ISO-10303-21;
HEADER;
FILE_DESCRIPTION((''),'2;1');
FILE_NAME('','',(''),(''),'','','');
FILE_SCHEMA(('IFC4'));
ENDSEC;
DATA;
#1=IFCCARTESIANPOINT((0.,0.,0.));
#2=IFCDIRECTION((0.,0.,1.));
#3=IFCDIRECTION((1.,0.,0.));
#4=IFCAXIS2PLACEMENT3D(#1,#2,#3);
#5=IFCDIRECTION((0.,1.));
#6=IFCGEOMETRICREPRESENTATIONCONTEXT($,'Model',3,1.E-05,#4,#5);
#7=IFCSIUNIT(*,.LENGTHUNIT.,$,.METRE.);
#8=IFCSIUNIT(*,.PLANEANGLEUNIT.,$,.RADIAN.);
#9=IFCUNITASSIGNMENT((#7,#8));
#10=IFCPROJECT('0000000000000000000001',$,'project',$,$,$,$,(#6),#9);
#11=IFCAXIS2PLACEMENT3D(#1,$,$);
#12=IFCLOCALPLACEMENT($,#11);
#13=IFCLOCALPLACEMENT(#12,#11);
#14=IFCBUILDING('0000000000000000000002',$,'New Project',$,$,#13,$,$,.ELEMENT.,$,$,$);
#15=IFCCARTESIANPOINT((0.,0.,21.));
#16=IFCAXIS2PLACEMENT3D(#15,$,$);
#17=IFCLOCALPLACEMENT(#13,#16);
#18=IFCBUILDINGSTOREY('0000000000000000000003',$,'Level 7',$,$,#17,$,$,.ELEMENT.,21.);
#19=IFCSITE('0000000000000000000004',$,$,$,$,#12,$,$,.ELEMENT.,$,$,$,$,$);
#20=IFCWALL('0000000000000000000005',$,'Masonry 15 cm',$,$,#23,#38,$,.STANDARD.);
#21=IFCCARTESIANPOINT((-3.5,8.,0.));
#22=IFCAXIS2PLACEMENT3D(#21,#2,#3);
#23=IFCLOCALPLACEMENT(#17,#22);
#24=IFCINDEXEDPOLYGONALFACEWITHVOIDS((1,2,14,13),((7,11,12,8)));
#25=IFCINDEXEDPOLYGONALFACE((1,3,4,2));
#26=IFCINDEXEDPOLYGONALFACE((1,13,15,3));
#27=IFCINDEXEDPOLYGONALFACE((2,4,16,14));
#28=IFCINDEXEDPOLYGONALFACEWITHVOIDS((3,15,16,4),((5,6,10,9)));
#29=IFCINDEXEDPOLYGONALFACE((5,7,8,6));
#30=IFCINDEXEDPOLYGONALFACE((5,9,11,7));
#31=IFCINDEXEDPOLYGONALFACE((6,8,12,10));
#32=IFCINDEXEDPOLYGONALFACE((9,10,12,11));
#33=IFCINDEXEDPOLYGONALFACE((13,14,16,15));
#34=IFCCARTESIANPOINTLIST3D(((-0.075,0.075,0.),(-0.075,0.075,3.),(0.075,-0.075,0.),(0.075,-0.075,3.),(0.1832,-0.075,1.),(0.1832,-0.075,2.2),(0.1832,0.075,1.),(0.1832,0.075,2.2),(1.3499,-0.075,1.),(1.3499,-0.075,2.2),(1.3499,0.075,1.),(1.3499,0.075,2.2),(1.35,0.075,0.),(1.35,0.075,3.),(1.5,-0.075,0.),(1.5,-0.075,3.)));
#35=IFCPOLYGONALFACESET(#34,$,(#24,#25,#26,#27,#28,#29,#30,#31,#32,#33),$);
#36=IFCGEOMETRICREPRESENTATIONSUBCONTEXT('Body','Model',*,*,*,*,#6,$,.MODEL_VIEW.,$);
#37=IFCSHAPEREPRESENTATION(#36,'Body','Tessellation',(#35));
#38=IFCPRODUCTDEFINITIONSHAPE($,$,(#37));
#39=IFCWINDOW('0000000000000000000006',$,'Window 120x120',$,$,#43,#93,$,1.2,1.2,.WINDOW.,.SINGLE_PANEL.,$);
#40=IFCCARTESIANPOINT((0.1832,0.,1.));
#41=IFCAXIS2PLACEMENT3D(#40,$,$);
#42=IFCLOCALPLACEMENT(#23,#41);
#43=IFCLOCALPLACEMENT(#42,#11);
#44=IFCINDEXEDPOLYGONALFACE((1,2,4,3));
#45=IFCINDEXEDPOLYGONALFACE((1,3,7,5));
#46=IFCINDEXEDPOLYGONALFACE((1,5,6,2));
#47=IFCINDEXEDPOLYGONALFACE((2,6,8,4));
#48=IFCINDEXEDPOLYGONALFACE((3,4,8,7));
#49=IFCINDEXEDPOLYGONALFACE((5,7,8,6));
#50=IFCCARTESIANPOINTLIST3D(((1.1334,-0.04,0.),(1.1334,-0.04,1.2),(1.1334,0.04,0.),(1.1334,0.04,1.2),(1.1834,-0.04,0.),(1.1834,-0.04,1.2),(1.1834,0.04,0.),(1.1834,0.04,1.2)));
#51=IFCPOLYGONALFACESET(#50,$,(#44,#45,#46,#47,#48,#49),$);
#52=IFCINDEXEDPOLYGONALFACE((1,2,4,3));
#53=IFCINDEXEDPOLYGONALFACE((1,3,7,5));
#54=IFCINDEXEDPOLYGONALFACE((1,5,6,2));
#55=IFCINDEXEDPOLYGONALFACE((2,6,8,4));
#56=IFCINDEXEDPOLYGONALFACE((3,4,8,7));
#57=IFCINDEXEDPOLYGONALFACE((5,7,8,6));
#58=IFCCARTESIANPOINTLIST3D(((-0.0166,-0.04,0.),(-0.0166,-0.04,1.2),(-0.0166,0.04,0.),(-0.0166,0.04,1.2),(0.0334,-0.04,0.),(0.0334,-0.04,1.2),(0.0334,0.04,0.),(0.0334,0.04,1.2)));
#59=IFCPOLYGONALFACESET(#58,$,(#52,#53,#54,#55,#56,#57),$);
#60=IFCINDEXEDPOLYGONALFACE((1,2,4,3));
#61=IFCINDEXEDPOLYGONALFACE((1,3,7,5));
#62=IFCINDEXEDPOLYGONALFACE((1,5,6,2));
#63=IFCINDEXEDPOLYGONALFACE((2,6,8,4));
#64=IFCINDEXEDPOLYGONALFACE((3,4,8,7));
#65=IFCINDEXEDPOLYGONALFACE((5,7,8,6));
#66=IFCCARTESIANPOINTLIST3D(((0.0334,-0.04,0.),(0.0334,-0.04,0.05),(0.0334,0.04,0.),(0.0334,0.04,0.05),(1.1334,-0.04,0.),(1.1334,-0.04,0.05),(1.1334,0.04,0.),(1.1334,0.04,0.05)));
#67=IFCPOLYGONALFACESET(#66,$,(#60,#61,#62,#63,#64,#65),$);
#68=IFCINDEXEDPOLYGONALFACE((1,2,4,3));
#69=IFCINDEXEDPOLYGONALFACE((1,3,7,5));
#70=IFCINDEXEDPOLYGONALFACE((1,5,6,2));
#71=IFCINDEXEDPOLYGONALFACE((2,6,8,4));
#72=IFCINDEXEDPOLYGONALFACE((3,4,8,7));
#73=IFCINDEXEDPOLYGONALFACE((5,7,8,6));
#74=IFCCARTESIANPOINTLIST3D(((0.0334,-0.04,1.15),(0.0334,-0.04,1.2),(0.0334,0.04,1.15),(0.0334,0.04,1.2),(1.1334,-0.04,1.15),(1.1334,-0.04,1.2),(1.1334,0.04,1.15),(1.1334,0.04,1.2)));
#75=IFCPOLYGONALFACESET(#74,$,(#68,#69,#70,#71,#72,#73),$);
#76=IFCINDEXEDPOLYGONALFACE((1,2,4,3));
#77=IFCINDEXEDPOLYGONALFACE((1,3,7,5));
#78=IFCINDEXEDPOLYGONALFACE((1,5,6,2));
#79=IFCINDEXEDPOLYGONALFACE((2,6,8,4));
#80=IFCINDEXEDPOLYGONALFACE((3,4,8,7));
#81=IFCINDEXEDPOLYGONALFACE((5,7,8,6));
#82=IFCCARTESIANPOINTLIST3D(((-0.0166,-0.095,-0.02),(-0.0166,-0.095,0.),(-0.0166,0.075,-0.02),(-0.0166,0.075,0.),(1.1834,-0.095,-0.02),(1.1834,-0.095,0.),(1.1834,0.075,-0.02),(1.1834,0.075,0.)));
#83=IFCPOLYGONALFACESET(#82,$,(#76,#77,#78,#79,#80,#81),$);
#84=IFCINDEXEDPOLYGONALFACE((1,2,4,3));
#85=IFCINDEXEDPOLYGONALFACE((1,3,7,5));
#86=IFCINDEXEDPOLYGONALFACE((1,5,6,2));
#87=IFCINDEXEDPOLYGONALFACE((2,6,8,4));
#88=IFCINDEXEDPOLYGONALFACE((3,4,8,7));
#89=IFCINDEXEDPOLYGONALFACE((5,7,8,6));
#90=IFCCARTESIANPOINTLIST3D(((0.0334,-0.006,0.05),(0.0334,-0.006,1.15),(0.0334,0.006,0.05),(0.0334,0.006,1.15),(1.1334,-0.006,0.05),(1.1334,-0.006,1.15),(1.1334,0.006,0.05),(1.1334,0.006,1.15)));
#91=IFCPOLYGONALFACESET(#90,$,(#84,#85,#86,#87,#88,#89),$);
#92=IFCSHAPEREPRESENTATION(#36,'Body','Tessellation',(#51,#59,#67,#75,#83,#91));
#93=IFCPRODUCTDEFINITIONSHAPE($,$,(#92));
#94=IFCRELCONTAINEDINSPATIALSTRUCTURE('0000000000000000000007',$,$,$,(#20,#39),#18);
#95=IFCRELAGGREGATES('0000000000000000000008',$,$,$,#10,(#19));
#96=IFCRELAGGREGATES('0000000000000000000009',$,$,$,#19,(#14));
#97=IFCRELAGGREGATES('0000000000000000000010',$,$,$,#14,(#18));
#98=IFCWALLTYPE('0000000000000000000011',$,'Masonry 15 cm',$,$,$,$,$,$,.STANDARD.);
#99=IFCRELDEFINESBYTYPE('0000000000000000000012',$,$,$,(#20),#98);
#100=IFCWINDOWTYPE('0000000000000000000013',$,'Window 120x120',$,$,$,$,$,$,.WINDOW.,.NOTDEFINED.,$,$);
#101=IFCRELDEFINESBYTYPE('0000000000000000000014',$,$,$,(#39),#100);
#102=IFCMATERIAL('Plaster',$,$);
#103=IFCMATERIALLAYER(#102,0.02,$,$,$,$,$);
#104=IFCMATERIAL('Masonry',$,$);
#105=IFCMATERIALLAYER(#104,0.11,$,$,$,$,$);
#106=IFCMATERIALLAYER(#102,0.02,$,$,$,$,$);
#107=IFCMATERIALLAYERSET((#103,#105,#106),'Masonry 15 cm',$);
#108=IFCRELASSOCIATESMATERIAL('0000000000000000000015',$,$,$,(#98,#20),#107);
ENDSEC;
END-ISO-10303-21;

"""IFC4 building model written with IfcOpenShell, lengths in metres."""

from ifc_helpers import new_model, si_unit, direction, frame, frame_2d, origin, origin_with_axes, place, context, subcontext, project, spatial, polyline, rectangle, outline, extrude, material, layer, layer_set, layer_usage, type_object, element, fill, save


model = new_model("IFC4")

# Units and contexts
model_context = context("Model", 3, precision=1e-05, world=origin_with_axes(), true_north=direction((0.0, 1.0)))
body_context = subcontext(model_context, "Body", "Model", "MODEL_VIEW")
ifc_project = project(units=[si_unit("LENGTHUNIT", "METRE"), si_unit("PLANEANGLEUNIT", "RADIAN")], contexts=[model_context])

# Site, building, storey
site_placement = place(None, origin())
site = spatial("IfcSite", under=ifc_project, at=site_placement, CompositionType="ELEMENT")
building_placement = place(site_placement, origin())
building = spatial("IfcBuilding", under=site, at=building_placement, Name="New Project", CompositionType="ELEMENT")
storey_placement = place(building_placement, frame((0.0, 0.0, 21.0)))
storey = spatial("IfcBuildingStorey", under=building, at=storey_placement, Name="Level 7", CompositionType="ELEMENT", Elevation=21.0)

# Shared definitions
ifc_material_1 = material(Name="Plaster")
ifc_layer_1 = layer(ifc_material_1, 0.02)
ifc_material_2 = material(Name="Masonry")
ifc_layer_2 = layer(ifc_material_2, 0.11)
ifc_layer_3 = layer(ifc_material_1, 0.02)
ifc_layer_set_1 = layer_set([ifc_layer_1, ifc_layer_2, ifc_layer_3], Name="Masonry 15 cm")
ifc_layer_usage_1 = layer_usage(ifc_layer_set_1, "AXIS2", "NEGATIVE", 0.075)
wall_type = type_object("IfcWallType", Name="Masonry 15 cm", PredefinedType="STANDARD", material=ifc_layer_set_1)
window_type = type_object("IfcWindowType", Name="Window 120x120", PartitioningType="NOTDEFINED", PredefinedType="WINDOW")

# Wall, opening, window
wall_1_placement = place(storey_placement, frame((-3.5, 8.0, 0.0), z_axis=(0.0, 0.0, 1.0), x_axis=(1.0, 0.0, 0.0)))
wall_1 = element("IfcWall", 1, at=wall_1_placement, inside=storey, type_object=wall_type, material=ifc_layer_usage_1, Name="Masonry 15 cm", PredefinedType="STANDARD", context=body_context, shape_type="SweptSolid", body=[
    extrude(outline(polyline([(0.075, -0.075), (1.5, -0.075), (1.35, 0.075), (-0.075, 0.075), (0.075, -0.075)])), origin(), (0.0, 0.0, 1.0), 3.0),
])
opening_1_placement = place(wall_1_placement, frame((0.1832, 0.0, 1.0)))
opening_1 = element("IfcOpeningElement", 2, at=opening_1_placement, cuts=wall_1, PredefinedType="OPENING", context=body_context, shape_type="SweptSolid", body=[
    extrude(rectangle(XDim=1.1667, YDim=0.25, at=frame_2d((0.5834, 0.0))), origin(), (0.0, 0.0, 1.0), 1.2),
])
window_1_placement = place(opening_1_placement, origin())
window_1 = element("IfcWindow", 3, at=window_1_placement, inside=storey, type_object=window_type, Name="Window 120x120", OverallHeight=1.2, OverallWidth=1.2, PartitioningType="SINGLE_PANEL", PredefinedType="WINDOW", context=body_context, shape_type="SweptSolid", body=[
    extrude(outline(polyline([(1.1834, 0.04), (1.1334, 0.04), (1.1334, -0.04), (1.1834, -0.04), (1.1834, 0.04)])), origin(), (0.0, 0.0, 1.0), 1.2),
    extrude(outline(polyline([(0.0334, 0.04), (-0.0166, 0.04), (-0.0166, -0.04), (0.0334, -0.04), (0.0334, 0.04)])), origin(), (0.0, 0.0, 1.0), 1.2),
    extrude(outline(polyline([(1.1334, 0.04), (0.0334, 0.04), (0.0334, -0.04), (1.1334, -0.04), (1.1334, 0.04)])), origin(), (0.0, 0.0, 1.0), 0.05),
    extrude(outline(polyline([(1.1334, 0.04), (0.0334, 0.04), (0.0334, -0.04), (1.1334, -0.04), (1.1334, 0.04)])), frame((0.0, 0.0, 1.15)), (0.0, 0.0, 1.0), 0.05),
    extrude(outline(polyline([(1.1834, 0.075), (-0.0166, 0.075), (-0.0166, -0.095), (1.1834, -0.095), (1.1834, 0.075)])), frame((0.0, 0.0, -0.02)), (0.0, 0.0, 1.0), 0.02),
    extrude(outline(polyline([(1.1334, 0.006), (0.0334, 0.006), (0.0334, -0.006), (1.1334, -0.006), (1.1334, 0.006)])), frame((0.0, 0.0, 0.05)), (0.0, 0.0, 1.0), 1.1),
])
fill(opening_1, window_1)

save(model, "model.ifc")
